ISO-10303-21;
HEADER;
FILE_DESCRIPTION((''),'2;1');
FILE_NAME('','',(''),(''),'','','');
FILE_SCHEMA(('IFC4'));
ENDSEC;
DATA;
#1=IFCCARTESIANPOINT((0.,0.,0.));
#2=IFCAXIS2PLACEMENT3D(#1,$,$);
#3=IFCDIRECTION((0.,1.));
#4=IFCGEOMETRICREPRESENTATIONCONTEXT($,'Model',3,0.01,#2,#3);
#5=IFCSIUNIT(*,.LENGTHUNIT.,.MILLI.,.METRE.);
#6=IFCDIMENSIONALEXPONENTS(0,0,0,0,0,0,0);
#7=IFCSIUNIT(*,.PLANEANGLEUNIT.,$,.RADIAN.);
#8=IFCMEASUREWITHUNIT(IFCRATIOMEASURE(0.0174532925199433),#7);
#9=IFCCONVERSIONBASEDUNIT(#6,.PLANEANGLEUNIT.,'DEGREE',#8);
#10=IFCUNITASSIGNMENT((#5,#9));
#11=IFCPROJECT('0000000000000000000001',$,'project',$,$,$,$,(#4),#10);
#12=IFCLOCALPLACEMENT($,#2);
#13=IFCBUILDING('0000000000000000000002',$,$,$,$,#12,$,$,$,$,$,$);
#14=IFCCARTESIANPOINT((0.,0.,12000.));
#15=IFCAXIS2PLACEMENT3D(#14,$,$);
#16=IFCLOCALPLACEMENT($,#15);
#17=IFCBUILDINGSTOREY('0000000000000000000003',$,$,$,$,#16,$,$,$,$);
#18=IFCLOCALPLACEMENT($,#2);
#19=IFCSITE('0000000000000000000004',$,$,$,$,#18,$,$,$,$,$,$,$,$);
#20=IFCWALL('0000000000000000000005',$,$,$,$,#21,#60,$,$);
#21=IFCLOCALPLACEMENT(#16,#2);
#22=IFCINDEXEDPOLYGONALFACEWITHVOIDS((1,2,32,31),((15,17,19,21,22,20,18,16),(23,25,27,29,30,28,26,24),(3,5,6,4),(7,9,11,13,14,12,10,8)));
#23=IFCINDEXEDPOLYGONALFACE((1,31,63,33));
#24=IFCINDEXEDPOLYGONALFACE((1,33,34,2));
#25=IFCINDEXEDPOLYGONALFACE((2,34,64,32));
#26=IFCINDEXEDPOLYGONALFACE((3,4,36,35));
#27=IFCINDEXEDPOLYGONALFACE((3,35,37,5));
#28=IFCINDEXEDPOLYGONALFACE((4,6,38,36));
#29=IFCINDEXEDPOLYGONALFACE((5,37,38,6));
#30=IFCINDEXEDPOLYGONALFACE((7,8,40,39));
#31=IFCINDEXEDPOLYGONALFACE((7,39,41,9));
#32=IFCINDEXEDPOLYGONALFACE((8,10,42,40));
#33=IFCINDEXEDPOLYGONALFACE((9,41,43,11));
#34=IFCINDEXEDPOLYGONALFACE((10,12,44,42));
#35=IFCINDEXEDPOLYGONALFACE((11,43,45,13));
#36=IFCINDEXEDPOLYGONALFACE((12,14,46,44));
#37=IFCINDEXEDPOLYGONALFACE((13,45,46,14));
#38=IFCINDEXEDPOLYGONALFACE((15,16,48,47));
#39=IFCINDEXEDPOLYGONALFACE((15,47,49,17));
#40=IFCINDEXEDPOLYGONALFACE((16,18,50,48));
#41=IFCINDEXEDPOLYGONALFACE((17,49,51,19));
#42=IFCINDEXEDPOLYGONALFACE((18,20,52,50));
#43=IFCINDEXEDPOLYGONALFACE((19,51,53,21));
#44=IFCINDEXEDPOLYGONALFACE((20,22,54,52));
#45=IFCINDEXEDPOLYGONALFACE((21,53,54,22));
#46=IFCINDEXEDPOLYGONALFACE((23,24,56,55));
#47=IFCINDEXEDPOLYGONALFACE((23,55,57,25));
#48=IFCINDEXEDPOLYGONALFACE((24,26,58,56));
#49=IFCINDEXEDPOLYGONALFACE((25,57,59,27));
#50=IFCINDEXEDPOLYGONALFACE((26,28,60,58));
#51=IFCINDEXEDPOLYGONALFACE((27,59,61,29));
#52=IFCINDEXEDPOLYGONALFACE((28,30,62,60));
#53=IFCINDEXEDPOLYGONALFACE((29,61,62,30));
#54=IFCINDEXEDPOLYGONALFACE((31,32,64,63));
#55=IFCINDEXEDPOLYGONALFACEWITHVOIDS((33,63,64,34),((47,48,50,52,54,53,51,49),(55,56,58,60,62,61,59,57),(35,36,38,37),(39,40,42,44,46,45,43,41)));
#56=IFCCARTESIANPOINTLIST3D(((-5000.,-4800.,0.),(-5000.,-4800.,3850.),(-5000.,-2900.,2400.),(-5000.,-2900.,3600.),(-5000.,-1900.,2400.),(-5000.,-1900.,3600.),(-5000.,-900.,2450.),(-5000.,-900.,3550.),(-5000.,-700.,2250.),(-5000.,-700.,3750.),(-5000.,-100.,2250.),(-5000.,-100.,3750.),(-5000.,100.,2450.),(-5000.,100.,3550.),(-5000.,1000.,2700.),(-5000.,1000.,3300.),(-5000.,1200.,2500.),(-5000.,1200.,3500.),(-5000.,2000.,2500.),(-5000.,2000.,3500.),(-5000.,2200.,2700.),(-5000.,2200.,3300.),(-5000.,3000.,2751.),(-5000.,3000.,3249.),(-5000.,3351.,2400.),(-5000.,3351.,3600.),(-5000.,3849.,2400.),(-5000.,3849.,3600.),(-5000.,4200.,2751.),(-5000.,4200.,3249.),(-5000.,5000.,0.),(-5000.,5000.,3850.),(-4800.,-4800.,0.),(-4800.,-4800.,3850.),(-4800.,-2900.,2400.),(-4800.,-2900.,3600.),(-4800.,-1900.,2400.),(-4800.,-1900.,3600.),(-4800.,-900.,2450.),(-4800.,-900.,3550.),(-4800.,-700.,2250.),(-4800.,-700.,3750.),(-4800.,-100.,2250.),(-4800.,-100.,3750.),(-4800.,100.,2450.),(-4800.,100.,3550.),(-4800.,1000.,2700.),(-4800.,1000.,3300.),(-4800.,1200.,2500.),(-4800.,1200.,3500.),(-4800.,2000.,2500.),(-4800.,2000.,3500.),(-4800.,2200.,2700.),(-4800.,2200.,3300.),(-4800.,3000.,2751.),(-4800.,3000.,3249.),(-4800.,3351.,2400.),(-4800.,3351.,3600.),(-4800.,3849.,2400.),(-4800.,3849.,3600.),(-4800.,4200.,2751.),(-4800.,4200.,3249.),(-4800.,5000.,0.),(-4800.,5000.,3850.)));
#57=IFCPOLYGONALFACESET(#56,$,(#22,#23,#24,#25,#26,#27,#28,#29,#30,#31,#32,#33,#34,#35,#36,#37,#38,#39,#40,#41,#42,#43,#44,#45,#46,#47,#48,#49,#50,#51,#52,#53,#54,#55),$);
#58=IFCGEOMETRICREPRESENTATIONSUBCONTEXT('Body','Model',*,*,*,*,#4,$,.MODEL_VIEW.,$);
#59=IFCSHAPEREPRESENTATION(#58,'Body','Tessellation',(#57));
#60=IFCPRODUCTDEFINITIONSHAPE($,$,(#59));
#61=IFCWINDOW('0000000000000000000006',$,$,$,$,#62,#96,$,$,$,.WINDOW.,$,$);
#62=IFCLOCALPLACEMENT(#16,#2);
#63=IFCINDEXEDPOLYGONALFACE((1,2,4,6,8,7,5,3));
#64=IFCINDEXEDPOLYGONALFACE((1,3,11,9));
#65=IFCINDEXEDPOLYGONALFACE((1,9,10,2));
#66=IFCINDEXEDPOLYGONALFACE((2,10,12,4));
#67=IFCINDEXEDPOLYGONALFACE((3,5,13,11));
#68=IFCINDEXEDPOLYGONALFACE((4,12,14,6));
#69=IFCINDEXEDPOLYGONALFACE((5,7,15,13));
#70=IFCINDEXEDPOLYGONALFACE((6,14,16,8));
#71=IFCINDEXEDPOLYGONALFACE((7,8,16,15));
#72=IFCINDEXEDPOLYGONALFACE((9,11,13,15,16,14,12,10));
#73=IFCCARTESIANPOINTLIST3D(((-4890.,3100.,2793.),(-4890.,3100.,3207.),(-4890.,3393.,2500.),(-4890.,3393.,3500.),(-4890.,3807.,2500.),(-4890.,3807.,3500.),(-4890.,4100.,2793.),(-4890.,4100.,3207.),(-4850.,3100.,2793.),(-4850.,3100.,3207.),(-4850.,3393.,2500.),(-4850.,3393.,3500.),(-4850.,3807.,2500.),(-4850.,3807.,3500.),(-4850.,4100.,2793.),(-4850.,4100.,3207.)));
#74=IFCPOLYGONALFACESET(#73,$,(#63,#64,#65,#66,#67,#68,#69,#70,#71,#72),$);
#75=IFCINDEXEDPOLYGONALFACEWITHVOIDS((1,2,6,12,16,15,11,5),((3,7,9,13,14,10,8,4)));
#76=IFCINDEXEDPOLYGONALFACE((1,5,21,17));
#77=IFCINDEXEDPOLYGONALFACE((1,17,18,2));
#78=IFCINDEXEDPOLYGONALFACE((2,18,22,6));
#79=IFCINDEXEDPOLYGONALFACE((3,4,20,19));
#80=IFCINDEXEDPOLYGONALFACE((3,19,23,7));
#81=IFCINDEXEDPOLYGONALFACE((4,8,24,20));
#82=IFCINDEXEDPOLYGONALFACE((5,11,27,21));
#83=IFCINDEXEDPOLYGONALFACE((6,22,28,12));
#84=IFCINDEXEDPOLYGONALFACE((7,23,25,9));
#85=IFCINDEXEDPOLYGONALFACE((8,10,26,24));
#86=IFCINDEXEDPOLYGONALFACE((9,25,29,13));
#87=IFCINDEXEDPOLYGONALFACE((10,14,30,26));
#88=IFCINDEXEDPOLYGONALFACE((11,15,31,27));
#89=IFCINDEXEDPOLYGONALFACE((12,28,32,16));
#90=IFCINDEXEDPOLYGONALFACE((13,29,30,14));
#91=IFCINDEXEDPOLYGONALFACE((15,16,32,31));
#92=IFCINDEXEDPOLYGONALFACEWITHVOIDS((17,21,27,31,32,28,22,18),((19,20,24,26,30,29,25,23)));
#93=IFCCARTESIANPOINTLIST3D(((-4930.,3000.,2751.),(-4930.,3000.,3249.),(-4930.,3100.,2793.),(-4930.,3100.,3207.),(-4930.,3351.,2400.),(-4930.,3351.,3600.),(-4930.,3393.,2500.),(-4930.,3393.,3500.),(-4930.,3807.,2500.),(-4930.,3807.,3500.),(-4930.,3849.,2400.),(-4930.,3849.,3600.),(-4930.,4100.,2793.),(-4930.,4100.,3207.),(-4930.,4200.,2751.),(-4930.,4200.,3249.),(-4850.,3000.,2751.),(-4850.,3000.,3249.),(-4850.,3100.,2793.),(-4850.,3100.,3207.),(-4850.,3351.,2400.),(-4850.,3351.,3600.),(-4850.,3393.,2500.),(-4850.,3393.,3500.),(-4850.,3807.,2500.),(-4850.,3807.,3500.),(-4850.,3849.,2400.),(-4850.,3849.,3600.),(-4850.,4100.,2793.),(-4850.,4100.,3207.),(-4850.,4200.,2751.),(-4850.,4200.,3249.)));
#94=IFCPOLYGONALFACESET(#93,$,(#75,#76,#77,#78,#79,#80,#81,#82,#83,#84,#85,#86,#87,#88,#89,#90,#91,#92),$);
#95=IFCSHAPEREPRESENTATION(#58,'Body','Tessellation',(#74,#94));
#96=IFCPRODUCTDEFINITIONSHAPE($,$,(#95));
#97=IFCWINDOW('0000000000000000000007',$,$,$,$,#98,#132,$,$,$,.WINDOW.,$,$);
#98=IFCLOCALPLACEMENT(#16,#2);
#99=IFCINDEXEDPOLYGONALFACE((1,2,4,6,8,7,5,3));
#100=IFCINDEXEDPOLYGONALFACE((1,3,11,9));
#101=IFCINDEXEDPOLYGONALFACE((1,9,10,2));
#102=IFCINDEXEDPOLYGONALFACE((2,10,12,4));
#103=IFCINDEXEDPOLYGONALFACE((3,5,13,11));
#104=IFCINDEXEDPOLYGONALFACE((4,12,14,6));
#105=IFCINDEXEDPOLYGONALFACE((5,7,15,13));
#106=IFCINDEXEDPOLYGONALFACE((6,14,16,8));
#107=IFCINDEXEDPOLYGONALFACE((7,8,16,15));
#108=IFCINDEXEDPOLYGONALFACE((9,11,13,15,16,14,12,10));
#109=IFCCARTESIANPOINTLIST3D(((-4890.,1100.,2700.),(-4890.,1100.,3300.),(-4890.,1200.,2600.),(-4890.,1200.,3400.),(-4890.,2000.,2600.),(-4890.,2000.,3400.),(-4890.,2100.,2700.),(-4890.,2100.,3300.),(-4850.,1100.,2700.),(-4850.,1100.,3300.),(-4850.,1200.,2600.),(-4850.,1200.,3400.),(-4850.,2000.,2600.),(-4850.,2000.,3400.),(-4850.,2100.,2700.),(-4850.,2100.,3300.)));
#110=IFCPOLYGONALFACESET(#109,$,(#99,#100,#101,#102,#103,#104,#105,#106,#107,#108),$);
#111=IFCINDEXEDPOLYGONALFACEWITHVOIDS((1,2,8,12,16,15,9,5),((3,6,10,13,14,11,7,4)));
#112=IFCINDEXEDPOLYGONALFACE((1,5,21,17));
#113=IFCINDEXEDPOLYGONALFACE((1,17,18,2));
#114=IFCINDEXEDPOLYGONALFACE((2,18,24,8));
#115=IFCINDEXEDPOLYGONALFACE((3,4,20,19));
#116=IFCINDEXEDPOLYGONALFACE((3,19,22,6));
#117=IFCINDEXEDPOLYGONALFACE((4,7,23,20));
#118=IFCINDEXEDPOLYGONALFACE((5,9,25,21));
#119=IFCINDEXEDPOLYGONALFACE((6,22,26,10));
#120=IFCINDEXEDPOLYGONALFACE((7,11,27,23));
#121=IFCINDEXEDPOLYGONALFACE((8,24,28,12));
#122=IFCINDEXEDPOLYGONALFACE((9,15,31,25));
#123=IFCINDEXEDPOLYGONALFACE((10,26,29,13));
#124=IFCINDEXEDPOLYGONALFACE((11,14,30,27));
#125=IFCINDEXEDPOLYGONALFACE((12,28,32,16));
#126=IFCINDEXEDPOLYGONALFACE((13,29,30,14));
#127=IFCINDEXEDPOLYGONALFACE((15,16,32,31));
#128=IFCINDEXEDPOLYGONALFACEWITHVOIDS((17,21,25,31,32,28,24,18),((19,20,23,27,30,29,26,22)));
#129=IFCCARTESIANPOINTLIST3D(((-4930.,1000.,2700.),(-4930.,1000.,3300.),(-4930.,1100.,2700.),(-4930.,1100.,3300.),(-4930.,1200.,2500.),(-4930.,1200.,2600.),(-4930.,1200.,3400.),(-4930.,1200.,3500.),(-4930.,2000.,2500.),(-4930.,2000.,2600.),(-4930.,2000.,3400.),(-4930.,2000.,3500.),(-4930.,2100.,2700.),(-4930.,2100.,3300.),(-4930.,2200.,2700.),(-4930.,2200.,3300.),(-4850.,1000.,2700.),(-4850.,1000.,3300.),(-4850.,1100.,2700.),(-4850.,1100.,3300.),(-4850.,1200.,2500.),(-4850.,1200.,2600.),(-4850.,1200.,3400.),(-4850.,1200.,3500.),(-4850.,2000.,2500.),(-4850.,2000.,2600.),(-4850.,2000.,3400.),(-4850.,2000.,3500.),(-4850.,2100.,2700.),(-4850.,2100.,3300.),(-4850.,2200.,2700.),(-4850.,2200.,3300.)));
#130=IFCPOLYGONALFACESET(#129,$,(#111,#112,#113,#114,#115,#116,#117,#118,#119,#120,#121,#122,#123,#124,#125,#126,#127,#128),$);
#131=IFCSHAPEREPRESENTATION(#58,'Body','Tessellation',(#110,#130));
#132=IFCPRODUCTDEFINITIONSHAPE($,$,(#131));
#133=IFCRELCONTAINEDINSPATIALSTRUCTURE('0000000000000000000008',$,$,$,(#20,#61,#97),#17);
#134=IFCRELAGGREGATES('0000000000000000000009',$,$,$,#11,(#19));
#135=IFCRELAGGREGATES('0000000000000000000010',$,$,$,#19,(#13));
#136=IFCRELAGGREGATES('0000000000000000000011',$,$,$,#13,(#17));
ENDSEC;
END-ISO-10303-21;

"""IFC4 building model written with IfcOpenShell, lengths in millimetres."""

from ifc_helpers import new_model, entity, si_unit, converted_unit, direction, frame, origin, origin_2d, place, context, subcontext, project, spatial, polyline, rectangle, outline, extrude, element, save


model = new_model("IFC4")

# Units and contexts
model_context = context("Model", 3, precision=0.01, world=origin(), true_north=direction((0.0, 1.0)))
body_context = subcontext(model_context, "Body", "Model", "MODEL_VIEW")
ifc_project = project(units=[si_unit("LENGTHUNIT", "METRE", prefix="MILLI"), converted_unit("PLANEANGLEUNIT", "DEGREE", entity("IfcRatioMeasure", 0.0174532925199433), si_unit("PLANEANGLEUNIT", "RADIAN"), dimensions=[0, 0, 0, 0, 0, 0, 0])], contexts=[model_context])

# Site, building, storey
site_placement = place(None, origin())
site = spatial("IfcSite", under=ifc_project, at=site_placement)
building_placement = place(None, origin())
building = spatial("IfcBuilding", under=site, at=building_placement)
storey_placement = place(None, frame((0.0, 0.0, 12000.0)))
storey = spatial("IfcBuildingStorey", under=building, at=storey_placement)

# Shared definitions
cartesian_point_1 = entity("IfcCartesianPoint", [-500.0, -207.0])
shared_polyline_1 = entity("IfcPolyline", [cartesian_point_1, entity("IfcCartesianPoint", [-500.0, 207.0]), entity("IfcCartesianPoint", [-207.0, 500.0]), entity("IfcCartesianPoint", [207.0, 500.0]), entity("IfcCartesianPoint", [500.0, 207.0]), entity("IfcCartesianPoint", [500.0, -207.0]), entity("IfcCartesianPoint", [207.0, -500.0]), entity("IfcCartesianPoint", [-207.0, -500.0]), cartesian_point_1])
cartesian_point_2 = entity("IfcCartesianPoint", [-500.0, -300.0])
shared_polyline_2 = entity("IfcPolyline", [cartesian_point_2, entity("IfcCartesianPoint", [-500.0, 300.0]), entity("IfcCartesianPoint", [-400.0, 400.0]), entity("IfcCartesianPoint", [400.0, 400.0]), entity("IfcCartesianPoint", [500.0, 300.0]), entity("IfcCartesianPoint", [500.0, -300.0]), entity("IfcCartesianPoint", [400.0, -400.0]), entity("IfcCartesianPoint", [-400.0, -400.0]), cartesian_point_2])

# Wall, openings
wall_1_placement = place(storey_placement, frame((-4900.0, 100.0, 0.0), z_axis=(0.0, 0.0, 1.0), x_axis=(0.0, -1.0, 0.0)))
wall_1 = element("IfcWall", 1, at=wall_1_placement, inside=storey, context=body_context, shape_type="SweptSolid", body=[
    extrude(rectangle(XDim=9800.0, YDim=200.0, at=origin_2d()), origin(), (0.0, 0.0, 1.0), 3850.0),
])
window_1_placement = place(wall_1_placement, frame((-3500.0, 50.0, 3000.0)))
opening_1_placement = place(window_1_placement, frame((0.0, 50.0, 0.0)))
element("IfcOpeningElement", 2, at=opening_1_placement, cuts=wall_1, context=body_context, shape_type="SweptSolid", body=[
    extrude(outline(polyline([(-600.0, -249.0), (-600.0, 249.0), (-249.0, 600.0), (249.0, 600.0), (600.0, 249.0), (600.0, -249.0), (249.0, -600.0), (-249.0, -600.0), (-600.0, -249.0)])), frame((0.0, 0.0, 0.0), z_axis=(0.0, -1.0, 0.0), x_axis=(1.0, 0.0, 0.0)), (0.0, 0.0, 1.0), 200.0),
])
window_2_placement = place(wall_1_placement, frame((-1500.0, 50.0, 3000.0)))
opening_2_placement = place(window_2_placement, frame((0.0, 50.0, 0.0)))
element("IfcOpeningElement", 3, at=opening_2_placement, cuts=wall_1, context=body_context, shape_type="SweptSolid", body=[
    extrude(outline(polyline([(-600.0, -300.0), (-600.0, 300.0), (-400.0, 500.0), (400.0, 500.0), (600.0, 300.0), (600.0, -300.0), (400.0, -500.0), (-400.0, -500.0), (-600.0, -300.0)])), frame((0.0, 0.0, 0.0), z_axis=(0.0, -1.0, 0.0), x_axis=(1.0, 0.0, 0.0)), (0.0, 0.0, 1.0), 200.0),
])
window_3_placement = place(wall_1_placement, frame((500.0, 50.0, 3000.0)))
opening_3_placement = place(window_3_placement, frame((0.0, 50.0, 0.0)))
element("IfcOpeningElement", 4, at=opening_3_placement, cuts=wall_1, context=body_context, shape_type="SweptSolid", body=[
    extrude(outline(polyline([(-500.0, -550.0), (-500.0, 550.0), (-300.0, 750.0), (300.0, 750.0), (500.0, 550.0), (500.0, -550.0), (300.0, -750.0), (-300.0, -750.0), (-500.0, -550.0)])), frame((0.0, 0.0, 0.0), z_axis=(0.0, -1.0, 0.0), x_axis=(1.0, 0.0, 0.0)), (0.0, 0.0, 1.0), 200.0),
])
window_4_placement = place(wall_1_placement, frame((2500.0, 50.0, 3000.0)))
opening_4_placement = place(window_4_placement, frame((0.0, 50.0, 0.0)))
element("IfcOpeningElement", 5, at=opening_4_placement, cuts=wall_1, context=body_context, shape_type="SweptSolid", body=[
    extrude(outline(polyline([(-500.0, -600.0), (-500.0, 600.0), (-500.0, 600.0), (500.0, 600.0), (500.0, 600.0), (500.0, -600.0), (500.0, -600.0), (-500.0, -600.0), (-500.0, -600.0)])), frame((0.0, 0.0, 0.0), z_axis=(0.0, -1.0, 0.0), x_axis=(1.0, 0.0, 0.0)), (0.0, 0.0, 1.0), 200.0),
])

# Windows
cartesian_point_3 = entity("IfcCartesianPoint", [-600.0, -249.0])
element("IfcWindow", 6, at=window_1_placement, inside=storey, PredefinedType="WINDOW", context=body_context, shape_type="SweptSolid", body=[
    entity("IfcExtrudedAreaSolid", entity("IfcArbitraryClosedProfileDef", "AREA", None, shared_polyline_1), entity("IfcAxis2Placement3D", entity("IfcCartesianPoint", [0.0, 0.0, 0.0]), entity("IfcDirection", [0.0, -1.0, 0.0]), entity("IfcDirection", [1.0, 0.0, 0.0])), entity("IfcDirection", [0.0, 0.0, 1.0]), 40.0),
    entity("IfcExtrudedAreaSolid", entity("IfcArbitraryProfileDefWithVoids", "AREA", None, entity("IfcPolyline", [cartesian_point_3, entity("IfcCartesianPoint", [-600.0, 249.0]), entity("IfcCartesianPoint", [-249.0, 600.0]), entity("IfcCartesianPoint", [249.0, 600.0]), entity("IfcCartesianPoint", [600.0, 249.0]), entity("IfcCartesianPoint", [600.0, -249.0]), entity("IfcCartesianPoint", [249.0, -600.0]), entity("IfcCartesianPoint", [-249.0, -600.0]), cartesian_point_3]), [shared_polyline_1]), entity("IfcAxis2Placement3D", entity("IfcCartesianPoint", [0.0, 0.0, 0.0]), entity("IfcDirection", [0.0, -1.0, 0.0]), entity("IfcDirection", [1.0, 0.0, 0.0])), entity("IfcDirection", [0.0, 0.0, 1.0]), 80.0),
])
cartesian_point_4 = entity("IfcCartesianPoint", [-600.0, -300.0])
element("IfcWindow", 7, at=window_2_placement, inside=storey, PredefinedType="WINDOW", context=body_context, shape_type="SweptSolid", body=[
    entity("IfcExtrudedAreaSolid", entity("IfcArbitraryClosedProfileDef", "AREA", None, shared_polyline_2), entity("IfcAxis2Placement3D", entity("IfcCartesianPoint", [0.0, 0.0, 0.0]), entity("IfcDirection", [0.0, -1.0, 0.0]), entity("IfcDirection", [1.0, 0.0, 0.0])), entity("IfcDirection", [0.0, 0.0, 1.0]), 40.0),
    entity("IfcExtrudedAreaSolid", entity("IfcArbitraryProfileDefWithVoids", "AREA", None, entity("IfcPolyline", [cartesian_point_4, entity("IfcCartesianPoint", [-600.0, 300.0]), entity("IfcCartesianPoint", [-400.0, 500.0]), entity("IfcCartesianPoint", [400.0, 500.0]), entity("IfcCartesianPoint", [600.0, 300.0]), entity("IfcCartesianPoint", [600.0, -300.0]), entity("IfcCartesianPoint", [400.0, -500.0]), entity("IfcCartesianPoint", [-400.0, -500.0]), cartesian_point_4]), [shared_polyline_2]), entity("IfcAxis2Placement3D", entity("IfcCartesianPoint", [0.0, 0.0, 0.0]), entity("IfcDirection", [0.0, -1.0, 0.0]), entity("IfcDirection", [1.0, 0.0, 0.0])), entity("IfcDirection", [0.0, 0.0, 1.0]), 80.0),
])

save(model, "model.ifc")
